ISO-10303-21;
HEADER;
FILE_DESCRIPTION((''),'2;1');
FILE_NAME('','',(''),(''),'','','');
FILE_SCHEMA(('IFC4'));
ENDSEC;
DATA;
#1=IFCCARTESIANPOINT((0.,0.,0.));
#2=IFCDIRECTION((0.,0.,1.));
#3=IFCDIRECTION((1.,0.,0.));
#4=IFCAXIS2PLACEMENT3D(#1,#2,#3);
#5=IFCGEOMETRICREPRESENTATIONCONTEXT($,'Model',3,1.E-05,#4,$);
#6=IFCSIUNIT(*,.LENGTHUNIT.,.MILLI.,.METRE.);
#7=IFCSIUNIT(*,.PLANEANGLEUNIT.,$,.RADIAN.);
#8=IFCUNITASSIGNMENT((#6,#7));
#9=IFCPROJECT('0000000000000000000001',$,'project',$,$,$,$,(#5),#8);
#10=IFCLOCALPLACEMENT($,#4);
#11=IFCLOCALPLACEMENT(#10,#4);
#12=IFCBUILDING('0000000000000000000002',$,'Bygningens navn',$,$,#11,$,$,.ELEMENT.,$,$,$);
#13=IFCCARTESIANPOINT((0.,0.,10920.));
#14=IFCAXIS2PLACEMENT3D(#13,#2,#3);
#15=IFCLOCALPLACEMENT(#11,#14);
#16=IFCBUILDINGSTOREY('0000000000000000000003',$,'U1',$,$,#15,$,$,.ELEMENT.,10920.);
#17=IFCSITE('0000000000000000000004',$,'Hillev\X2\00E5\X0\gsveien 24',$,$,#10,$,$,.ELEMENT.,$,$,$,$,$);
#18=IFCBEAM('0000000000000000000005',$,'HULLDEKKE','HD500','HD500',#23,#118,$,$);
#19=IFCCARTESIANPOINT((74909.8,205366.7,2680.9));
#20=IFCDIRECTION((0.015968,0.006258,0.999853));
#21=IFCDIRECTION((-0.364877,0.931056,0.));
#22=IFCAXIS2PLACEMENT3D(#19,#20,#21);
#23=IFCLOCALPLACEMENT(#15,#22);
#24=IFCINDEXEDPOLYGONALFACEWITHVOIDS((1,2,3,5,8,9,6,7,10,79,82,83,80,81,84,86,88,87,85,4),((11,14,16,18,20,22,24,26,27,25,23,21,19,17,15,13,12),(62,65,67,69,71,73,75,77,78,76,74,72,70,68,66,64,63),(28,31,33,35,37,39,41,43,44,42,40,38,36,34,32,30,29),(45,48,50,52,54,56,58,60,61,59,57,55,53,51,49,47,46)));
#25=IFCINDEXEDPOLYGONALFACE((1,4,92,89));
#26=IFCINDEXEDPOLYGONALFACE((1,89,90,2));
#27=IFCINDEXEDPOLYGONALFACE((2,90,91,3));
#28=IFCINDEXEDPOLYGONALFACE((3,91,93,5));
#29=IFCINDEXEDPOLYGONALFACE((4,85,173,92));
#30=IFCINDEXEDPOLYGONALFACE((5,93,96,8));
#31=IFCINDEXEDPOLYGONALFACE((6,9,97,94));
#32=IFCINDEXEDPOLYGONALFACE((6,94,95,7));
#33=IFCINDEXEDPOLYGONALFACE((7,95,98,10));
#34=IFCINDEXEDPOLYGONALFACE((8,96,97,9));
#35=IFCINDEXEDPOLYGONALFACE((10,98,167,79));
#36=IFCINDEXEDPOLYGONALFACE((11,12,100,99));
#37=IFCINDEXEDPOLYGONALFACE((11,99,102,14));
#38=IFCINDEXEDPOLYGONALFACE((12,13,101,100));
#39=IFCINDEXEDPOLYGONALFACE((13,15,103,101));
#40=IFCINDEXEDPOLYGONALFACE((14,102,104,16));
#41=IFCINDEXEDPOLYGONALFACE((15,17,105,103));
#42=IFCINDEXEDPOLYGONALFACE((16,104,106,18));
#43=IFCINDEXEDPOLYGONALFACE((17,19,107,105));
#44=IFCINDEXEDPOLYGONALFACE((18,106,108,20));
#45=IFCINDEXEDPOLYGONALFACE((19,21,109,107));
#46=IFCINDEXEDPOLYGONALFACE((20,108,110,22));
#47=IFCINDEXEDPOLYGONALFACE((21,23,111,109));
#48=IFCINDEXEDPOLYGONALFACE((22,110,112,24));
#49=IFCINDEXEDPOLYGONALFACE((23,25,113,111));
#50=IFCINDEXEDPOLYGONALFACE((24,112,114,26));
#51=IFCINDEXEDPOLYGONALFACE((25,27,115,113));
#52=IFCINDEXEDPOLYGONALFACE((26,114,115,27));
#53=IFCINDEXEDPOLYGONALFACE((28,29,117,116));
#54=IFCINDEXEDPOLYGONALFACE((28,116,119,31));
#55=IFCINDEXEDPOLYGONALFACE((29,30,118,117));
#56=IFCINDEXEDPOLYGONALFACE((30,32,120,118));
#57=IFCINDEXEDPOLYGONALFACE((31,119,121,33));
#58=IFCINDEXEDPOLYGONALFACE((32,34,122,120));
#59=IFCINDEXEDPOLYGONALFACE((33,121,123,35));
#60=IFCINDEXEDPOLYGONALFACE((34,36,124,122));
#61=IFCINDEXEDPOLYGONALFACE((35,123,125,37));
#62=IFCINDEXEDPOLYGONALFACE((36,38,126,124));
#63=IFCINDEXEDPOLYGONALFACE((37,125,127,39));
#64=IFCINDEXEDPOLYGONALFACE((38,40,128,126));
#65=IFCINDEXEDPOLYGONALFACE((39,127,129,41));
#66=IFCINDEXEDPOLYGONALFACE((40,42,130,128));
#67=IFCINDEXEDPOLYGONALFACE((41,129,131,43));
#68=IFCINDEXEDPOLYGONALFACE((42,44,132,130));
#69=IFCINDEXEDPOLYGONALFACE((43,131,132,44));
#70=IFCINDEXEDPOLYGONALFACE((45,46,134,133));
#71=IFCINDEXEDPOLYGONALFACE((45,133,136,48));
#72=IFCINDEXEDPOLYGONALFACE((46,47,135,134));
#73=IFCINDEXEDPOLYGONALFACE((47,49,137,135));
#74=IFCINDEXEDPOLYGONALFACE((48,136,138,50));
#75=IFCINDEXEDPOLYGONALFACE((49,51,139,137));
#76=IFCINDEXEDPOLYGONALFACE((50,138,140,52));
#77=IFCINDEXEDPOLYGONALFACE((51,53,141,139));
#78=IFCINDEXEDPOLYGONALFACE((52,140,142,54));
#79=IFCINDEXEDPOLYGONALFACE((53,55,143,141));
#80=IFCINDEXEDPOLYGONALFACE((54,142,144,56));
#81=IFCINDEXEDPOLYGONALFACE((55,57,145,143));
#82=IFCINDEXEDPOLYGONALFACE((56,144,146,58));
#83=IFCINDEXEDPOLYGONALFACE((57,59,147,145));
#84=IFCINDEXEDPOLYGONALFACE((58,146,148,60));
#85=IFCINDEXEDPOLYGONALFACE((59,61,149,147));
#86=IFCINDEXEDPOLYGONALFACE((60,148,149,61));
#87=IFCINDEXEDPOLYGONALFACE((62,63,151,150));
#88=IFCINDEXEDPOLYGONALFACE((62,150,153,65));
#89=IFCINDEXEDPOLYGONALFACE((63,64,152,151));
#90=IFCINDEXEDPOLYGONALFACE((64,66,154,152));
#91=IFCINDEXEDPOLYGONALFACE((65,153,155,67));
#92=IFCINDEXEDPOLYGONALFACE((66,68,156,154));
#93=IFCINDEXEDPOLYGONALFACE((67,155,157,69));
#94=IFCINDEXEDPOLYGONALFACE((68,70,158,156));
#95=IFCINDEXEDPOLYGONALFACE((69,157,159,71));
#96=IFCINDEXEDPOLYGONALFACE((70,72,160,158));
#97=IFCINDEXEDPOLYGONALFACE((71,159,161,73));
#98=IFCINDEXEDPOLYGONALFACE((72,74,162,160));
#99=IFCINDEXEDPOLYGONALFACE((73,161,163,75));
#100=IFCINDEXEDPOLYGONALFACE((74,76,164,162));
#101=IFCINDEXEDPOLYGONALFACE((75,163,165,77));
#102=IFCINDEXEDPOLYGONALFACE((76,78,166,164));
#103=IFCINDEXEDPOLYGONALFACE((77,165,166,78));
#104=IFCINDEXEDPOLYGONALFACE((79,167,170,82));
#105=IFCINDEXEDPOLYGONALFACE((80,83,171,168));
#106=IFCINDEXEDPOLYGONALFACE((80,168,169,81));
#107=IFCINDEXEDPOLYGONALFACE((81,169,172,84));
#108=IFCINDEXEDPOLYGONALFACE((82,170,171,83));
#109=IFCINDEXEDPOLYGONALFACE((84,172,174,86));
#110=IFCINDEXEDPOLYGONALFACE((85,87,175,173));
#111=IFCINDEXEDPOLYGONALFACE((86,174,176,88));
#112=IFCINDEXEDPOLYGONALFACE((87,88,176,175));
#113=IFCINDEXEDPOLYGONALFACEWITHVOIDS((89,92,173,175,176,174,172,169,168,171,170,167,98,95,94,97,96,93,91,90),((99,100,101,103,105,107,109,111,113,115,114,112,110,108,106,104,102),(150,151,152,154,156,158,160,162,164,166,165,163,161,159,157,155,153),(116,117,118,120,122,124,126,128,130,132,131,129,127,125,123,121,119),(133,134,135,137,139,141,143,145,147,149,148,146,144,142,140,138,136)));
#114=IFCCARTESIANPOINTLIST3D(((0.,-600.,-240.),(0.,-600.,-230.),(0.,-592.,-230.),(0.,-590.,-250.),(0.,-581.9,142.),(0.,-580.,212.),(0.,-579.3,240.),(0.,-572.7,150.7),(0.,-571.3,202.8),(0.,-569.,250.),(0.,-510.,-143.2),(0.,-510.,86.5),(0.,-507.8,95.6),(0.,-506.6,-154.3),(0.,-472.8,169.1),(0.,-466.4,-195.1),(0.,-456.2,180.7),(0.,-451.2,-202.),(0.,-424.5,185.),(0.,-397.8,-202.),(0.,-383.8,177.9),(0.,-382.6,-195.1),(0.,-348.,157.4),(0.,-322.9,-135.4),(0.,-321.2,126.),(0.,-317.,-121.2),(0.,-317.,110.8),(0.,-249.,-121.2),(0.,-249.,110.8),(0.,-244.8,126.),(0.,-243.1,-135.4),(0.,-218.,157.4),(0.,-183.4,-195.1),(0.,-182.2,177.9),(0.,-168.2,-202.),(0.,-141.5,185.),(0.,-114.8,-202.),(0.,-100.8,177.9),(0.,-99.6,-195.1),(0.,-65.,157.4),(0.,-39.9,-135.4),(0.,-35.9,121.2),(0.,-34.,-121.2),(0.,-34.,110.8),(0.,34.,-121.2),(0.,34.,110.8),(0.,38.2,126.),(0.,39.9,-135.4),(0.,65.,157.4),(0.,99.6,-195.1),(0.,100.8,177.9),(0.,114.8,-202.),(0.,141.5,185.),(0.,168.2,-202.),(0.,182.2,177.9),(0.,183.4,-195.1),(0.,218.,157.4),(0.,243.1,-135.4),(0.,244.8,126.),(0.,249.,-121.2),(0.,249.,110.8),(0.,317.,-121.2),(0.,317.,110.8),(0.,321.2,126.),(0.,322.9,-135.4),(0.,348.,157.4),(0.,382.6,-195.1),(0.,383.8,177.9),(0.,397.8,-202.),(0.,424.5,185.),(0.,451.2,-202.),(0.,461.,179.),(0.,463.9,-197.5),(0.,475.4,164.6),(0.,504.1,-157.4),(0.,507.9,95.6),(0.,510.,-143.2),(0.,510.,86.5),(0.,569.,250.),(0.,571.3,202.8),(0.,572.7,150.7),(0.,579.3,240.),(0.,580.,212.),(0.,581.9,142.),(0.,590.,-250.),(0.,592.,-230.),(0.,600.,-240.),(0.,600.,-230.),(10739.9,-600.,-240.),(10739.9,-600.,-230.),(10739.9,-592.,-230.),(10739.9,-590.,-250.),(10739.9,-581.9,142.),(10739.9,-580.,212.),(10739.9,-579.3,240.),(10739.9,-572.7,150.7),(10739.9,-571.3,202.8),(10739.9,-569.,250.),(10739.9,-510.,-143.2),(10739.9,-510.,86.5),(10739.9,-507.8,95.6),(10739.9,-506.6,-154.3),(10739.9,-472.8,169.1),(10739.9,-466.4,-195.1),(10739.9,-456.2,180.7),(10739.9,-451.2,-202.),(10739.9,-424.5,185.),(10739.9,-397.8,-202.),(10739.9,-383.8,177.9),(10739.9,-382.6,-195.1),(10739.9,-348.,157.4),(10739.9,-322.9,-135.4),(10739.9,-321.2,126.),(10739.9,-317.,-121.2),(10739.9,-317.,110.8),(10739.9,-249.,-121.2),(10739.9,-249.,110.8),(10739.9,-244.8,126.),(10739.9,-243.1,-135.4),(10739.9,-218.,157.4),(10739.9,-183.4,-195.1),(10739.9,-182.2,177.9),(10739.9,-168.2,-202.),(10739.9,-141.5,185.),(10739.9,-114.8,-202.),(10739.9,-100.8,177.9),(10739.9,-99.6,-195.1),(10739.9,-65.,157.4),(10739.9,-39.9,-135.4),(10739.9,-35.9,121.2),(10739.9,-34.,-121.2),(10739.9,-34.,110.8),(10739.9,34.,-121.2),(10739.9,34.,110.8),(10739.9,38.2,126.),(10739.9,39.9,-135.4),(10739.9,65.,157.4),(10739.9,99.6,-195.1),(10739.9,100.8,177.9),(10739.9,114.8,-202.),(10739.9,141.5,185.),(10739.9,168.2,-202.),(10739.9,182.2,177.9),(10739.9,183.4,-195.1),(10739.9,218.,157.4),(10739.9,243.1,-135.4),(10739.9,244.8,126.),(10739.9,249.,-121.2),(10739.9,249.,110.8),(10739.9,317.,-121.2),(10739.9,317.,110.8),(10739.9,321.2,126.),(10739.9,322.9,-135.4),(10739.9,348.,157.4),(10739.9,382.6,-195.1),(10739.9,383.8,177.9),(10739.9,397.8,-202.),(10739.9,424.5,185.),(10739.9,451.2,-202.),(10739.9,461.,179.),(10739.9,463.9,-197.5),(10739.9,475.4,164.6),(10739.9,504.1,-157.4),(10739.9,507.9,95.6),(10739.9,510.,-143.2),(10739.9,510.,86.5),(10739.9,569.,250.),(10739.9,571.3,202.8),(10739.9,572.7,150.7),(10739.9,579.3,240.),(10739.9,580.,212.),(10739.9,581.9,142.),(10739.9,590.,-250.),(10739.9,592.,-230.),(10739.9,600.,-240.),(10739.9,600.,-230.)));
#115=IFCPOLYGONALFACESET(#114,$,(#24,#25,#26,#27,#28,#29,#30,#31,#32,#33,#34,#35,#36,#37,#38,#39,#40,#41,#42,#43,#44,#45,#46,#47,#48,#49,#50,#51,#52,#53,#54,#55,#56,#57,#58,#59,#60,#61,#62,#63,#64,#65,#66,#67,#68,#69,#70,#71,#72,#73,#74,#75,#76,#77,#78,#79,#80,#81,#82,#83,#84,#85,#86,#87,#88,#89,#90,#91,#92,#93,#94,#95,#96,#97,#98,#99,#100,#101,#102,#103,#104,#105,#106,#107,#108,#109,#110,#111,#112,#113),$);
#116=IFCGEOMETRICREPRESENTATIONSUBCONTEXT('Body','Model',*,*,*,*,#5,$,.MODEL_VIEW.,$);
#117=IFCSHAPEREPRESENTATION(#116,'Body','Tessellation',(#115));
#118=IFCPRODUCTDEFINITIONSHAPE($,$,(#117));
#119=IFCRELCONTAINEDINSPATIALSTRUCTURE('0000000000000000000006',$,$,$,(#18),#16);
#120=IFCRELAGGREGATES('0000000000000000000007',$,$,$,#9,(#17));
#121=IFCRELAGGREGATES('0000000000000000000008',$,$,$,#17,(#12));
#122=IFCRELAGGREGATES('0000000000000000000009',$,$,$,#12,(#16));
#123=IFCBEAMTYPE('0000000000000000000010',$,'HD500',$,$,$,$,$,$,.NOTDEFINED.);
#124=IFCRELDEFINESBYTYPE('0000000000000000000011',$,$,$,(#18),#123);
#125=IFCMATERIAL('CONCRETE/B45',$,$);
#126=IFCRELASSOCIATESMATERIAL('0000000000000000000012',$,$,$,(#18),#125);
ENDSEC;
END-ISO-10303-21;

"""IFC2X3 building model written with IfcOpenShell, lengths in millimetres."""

from ifc_helpers import new_model, si_unit, frame, origin_with_axes, place, context, subcontext, project, spatial, polyline, outline, extrude, material, type_object, element, save


model = new_model("IFC2X3")

# Units and contexts
model_context = context("Model", 3, precision=1e-05, world=origin_with_axes())
body_context = subcontext(model_context, "Body", "Model", "MODEL_VIEW")
ifc_project = project(units=[si_unit("LENGTHUNIT", "METRE", prefix="MILLI"), si_unit("PLANEANGLEUNIT", "RADIAN")], contexts=[model_context])

# Site, building, storey
site_placement = place(None, origin_with_axes())
site = spatial("IfcSite", under=ifc_project, at=site_placement, Name="Hillevågsveien 24", CompositionType="ELEMENT")
building_placement = place(site_placement, origin_with_axes())
building = spatial("IfcBuilding", under=site, at=building_placement, Name="Bygningens navn", CompositionType="ELEMENT")
storey_placement = place(building_placement, frame((0.0, 0.0, 10920.0), z_axis=(0.0, 0.0, 1.0), x_axis=(1.0, 0.0, 0.0)))
storey = spatial("IfcBuildingStorey", under=building, at=storey_placement, Name="U1", CompositionType="ELEMENT", Elevation=10920.0)

# Beam
ifc_material_1 = material(Name="CONCRETE/B45")
beam_type_1 = type_object("IfcBeamType", Name="HD500", PredefinedType="NOTDEFINED")
beam_1_placement = place(storey_placement, frame((74909.8, 205366.7, 2680.9), z_axis=(0.015968, 0.006258, 0.999853), x_axis=(-0.364877, 0.931056, 0.0)))
element("IfcBeam", 1, at=beam_1_placement, inside=storey, type_object=beam_type_1, material=ifc_material_1, Name="HULLDEKKE", Description="HD500", ObjectType="HD500", context=body_context, shape_type="SweptSolid", body=[
    extrude(outline(polyline([(581.9, 142.0), (592.0, -230.0), (600.0, -230.0), (600.0, -240.0), (590.0, -250.0), (-590.0, -250.0), (-600.0, -240.0), (-600.0, -230.0), (-592.0, -230.0), (-581.9, 142.0), (-572.7, 150.7), (-571.3, 202.8), (-580.0, 212.0), (-579.3, 240.0), (-569.0, 250.0), (569.0, 250.0), (579.3, 240.0), (580.0, 212.0), (571.3, 202.8), (572.7, 150.7), (581.9, 142.0)]), holes=[polyline([(466.4, -195.1), (506.6, -154.3), (510.0, -143.2), (510.0, 86.5), (507.8, 95.6), (472.8, 169.1), (456.2, 180.7), (424.5, 185.0), (383.8, 177.9), (348.0, 157.4), (321.2, 126.0), (317.0, 110.8), (317.0, -121.2), (322.9, -135.4), (382.6, -195.1), (397.8, -202.0), (451.2, -202.0), (466.4, -195.1)]), polyline([(183.4, -195.1), (243.1, -135.4), (249.0, -121.2), (249.0, 110.8), (244.8, 126.0), (218.0, 157.4), (182.2, 177.9), (141.5, 185.0), (100.8, 177.9), (65.0, 157.4), (35.9, 121.2), (34.0, 110.8), (34.0, -121.2), (39.9, -135.4), (99.6, -195.1), (114.8, -202.0), (168.2, -202.0), (183.4, -195.1)]), polyline([(-99.6, -195.1), (-39.9, -135.4), (-34.0, -121.2), (-34.0, 110.8), (-38.2, 126.0), (-65.0, 157.4), (-100.8, 177.9), (-141.5, 185.0), (-182.2, 177.9), (-218.0, 157.4), (-244.8, 126.0), (-249.0, 110.8), (-249.0, -121.2), (-243.1, -135.4), (-183.4, -195.1), (-168.2, -202.0), (-114.8, -202.0), (-99.6, -195.1)]), polyline([(-382.6, -195.1), (-322.9, -135.4), (-317.0, -121.2), (-317.0, 110.8), (-321.2, 126.0), (-348.0, 157.4), (-383.8, 177.9), (-424.5, 185.0), (-461.0, 179.0), (-475.4, 164.6), (-507.9, 95.6), (-510.0, 86.5), (-510.0, -143.2), (-504.1, -157.4), (-463.9, -197.5), (-451.2, -202.0), (-397.8, -202.0), (-382.6, -195.1)])]), frame((10739.9, 0.0, 0.0), z_axis=(-1.0, 0.0, 0.0), x_axis=(0.0, -1.0, 0.0)), (0.0, 0.0, 1.0), 10739.9),
])

save(model, "model.ifc")
